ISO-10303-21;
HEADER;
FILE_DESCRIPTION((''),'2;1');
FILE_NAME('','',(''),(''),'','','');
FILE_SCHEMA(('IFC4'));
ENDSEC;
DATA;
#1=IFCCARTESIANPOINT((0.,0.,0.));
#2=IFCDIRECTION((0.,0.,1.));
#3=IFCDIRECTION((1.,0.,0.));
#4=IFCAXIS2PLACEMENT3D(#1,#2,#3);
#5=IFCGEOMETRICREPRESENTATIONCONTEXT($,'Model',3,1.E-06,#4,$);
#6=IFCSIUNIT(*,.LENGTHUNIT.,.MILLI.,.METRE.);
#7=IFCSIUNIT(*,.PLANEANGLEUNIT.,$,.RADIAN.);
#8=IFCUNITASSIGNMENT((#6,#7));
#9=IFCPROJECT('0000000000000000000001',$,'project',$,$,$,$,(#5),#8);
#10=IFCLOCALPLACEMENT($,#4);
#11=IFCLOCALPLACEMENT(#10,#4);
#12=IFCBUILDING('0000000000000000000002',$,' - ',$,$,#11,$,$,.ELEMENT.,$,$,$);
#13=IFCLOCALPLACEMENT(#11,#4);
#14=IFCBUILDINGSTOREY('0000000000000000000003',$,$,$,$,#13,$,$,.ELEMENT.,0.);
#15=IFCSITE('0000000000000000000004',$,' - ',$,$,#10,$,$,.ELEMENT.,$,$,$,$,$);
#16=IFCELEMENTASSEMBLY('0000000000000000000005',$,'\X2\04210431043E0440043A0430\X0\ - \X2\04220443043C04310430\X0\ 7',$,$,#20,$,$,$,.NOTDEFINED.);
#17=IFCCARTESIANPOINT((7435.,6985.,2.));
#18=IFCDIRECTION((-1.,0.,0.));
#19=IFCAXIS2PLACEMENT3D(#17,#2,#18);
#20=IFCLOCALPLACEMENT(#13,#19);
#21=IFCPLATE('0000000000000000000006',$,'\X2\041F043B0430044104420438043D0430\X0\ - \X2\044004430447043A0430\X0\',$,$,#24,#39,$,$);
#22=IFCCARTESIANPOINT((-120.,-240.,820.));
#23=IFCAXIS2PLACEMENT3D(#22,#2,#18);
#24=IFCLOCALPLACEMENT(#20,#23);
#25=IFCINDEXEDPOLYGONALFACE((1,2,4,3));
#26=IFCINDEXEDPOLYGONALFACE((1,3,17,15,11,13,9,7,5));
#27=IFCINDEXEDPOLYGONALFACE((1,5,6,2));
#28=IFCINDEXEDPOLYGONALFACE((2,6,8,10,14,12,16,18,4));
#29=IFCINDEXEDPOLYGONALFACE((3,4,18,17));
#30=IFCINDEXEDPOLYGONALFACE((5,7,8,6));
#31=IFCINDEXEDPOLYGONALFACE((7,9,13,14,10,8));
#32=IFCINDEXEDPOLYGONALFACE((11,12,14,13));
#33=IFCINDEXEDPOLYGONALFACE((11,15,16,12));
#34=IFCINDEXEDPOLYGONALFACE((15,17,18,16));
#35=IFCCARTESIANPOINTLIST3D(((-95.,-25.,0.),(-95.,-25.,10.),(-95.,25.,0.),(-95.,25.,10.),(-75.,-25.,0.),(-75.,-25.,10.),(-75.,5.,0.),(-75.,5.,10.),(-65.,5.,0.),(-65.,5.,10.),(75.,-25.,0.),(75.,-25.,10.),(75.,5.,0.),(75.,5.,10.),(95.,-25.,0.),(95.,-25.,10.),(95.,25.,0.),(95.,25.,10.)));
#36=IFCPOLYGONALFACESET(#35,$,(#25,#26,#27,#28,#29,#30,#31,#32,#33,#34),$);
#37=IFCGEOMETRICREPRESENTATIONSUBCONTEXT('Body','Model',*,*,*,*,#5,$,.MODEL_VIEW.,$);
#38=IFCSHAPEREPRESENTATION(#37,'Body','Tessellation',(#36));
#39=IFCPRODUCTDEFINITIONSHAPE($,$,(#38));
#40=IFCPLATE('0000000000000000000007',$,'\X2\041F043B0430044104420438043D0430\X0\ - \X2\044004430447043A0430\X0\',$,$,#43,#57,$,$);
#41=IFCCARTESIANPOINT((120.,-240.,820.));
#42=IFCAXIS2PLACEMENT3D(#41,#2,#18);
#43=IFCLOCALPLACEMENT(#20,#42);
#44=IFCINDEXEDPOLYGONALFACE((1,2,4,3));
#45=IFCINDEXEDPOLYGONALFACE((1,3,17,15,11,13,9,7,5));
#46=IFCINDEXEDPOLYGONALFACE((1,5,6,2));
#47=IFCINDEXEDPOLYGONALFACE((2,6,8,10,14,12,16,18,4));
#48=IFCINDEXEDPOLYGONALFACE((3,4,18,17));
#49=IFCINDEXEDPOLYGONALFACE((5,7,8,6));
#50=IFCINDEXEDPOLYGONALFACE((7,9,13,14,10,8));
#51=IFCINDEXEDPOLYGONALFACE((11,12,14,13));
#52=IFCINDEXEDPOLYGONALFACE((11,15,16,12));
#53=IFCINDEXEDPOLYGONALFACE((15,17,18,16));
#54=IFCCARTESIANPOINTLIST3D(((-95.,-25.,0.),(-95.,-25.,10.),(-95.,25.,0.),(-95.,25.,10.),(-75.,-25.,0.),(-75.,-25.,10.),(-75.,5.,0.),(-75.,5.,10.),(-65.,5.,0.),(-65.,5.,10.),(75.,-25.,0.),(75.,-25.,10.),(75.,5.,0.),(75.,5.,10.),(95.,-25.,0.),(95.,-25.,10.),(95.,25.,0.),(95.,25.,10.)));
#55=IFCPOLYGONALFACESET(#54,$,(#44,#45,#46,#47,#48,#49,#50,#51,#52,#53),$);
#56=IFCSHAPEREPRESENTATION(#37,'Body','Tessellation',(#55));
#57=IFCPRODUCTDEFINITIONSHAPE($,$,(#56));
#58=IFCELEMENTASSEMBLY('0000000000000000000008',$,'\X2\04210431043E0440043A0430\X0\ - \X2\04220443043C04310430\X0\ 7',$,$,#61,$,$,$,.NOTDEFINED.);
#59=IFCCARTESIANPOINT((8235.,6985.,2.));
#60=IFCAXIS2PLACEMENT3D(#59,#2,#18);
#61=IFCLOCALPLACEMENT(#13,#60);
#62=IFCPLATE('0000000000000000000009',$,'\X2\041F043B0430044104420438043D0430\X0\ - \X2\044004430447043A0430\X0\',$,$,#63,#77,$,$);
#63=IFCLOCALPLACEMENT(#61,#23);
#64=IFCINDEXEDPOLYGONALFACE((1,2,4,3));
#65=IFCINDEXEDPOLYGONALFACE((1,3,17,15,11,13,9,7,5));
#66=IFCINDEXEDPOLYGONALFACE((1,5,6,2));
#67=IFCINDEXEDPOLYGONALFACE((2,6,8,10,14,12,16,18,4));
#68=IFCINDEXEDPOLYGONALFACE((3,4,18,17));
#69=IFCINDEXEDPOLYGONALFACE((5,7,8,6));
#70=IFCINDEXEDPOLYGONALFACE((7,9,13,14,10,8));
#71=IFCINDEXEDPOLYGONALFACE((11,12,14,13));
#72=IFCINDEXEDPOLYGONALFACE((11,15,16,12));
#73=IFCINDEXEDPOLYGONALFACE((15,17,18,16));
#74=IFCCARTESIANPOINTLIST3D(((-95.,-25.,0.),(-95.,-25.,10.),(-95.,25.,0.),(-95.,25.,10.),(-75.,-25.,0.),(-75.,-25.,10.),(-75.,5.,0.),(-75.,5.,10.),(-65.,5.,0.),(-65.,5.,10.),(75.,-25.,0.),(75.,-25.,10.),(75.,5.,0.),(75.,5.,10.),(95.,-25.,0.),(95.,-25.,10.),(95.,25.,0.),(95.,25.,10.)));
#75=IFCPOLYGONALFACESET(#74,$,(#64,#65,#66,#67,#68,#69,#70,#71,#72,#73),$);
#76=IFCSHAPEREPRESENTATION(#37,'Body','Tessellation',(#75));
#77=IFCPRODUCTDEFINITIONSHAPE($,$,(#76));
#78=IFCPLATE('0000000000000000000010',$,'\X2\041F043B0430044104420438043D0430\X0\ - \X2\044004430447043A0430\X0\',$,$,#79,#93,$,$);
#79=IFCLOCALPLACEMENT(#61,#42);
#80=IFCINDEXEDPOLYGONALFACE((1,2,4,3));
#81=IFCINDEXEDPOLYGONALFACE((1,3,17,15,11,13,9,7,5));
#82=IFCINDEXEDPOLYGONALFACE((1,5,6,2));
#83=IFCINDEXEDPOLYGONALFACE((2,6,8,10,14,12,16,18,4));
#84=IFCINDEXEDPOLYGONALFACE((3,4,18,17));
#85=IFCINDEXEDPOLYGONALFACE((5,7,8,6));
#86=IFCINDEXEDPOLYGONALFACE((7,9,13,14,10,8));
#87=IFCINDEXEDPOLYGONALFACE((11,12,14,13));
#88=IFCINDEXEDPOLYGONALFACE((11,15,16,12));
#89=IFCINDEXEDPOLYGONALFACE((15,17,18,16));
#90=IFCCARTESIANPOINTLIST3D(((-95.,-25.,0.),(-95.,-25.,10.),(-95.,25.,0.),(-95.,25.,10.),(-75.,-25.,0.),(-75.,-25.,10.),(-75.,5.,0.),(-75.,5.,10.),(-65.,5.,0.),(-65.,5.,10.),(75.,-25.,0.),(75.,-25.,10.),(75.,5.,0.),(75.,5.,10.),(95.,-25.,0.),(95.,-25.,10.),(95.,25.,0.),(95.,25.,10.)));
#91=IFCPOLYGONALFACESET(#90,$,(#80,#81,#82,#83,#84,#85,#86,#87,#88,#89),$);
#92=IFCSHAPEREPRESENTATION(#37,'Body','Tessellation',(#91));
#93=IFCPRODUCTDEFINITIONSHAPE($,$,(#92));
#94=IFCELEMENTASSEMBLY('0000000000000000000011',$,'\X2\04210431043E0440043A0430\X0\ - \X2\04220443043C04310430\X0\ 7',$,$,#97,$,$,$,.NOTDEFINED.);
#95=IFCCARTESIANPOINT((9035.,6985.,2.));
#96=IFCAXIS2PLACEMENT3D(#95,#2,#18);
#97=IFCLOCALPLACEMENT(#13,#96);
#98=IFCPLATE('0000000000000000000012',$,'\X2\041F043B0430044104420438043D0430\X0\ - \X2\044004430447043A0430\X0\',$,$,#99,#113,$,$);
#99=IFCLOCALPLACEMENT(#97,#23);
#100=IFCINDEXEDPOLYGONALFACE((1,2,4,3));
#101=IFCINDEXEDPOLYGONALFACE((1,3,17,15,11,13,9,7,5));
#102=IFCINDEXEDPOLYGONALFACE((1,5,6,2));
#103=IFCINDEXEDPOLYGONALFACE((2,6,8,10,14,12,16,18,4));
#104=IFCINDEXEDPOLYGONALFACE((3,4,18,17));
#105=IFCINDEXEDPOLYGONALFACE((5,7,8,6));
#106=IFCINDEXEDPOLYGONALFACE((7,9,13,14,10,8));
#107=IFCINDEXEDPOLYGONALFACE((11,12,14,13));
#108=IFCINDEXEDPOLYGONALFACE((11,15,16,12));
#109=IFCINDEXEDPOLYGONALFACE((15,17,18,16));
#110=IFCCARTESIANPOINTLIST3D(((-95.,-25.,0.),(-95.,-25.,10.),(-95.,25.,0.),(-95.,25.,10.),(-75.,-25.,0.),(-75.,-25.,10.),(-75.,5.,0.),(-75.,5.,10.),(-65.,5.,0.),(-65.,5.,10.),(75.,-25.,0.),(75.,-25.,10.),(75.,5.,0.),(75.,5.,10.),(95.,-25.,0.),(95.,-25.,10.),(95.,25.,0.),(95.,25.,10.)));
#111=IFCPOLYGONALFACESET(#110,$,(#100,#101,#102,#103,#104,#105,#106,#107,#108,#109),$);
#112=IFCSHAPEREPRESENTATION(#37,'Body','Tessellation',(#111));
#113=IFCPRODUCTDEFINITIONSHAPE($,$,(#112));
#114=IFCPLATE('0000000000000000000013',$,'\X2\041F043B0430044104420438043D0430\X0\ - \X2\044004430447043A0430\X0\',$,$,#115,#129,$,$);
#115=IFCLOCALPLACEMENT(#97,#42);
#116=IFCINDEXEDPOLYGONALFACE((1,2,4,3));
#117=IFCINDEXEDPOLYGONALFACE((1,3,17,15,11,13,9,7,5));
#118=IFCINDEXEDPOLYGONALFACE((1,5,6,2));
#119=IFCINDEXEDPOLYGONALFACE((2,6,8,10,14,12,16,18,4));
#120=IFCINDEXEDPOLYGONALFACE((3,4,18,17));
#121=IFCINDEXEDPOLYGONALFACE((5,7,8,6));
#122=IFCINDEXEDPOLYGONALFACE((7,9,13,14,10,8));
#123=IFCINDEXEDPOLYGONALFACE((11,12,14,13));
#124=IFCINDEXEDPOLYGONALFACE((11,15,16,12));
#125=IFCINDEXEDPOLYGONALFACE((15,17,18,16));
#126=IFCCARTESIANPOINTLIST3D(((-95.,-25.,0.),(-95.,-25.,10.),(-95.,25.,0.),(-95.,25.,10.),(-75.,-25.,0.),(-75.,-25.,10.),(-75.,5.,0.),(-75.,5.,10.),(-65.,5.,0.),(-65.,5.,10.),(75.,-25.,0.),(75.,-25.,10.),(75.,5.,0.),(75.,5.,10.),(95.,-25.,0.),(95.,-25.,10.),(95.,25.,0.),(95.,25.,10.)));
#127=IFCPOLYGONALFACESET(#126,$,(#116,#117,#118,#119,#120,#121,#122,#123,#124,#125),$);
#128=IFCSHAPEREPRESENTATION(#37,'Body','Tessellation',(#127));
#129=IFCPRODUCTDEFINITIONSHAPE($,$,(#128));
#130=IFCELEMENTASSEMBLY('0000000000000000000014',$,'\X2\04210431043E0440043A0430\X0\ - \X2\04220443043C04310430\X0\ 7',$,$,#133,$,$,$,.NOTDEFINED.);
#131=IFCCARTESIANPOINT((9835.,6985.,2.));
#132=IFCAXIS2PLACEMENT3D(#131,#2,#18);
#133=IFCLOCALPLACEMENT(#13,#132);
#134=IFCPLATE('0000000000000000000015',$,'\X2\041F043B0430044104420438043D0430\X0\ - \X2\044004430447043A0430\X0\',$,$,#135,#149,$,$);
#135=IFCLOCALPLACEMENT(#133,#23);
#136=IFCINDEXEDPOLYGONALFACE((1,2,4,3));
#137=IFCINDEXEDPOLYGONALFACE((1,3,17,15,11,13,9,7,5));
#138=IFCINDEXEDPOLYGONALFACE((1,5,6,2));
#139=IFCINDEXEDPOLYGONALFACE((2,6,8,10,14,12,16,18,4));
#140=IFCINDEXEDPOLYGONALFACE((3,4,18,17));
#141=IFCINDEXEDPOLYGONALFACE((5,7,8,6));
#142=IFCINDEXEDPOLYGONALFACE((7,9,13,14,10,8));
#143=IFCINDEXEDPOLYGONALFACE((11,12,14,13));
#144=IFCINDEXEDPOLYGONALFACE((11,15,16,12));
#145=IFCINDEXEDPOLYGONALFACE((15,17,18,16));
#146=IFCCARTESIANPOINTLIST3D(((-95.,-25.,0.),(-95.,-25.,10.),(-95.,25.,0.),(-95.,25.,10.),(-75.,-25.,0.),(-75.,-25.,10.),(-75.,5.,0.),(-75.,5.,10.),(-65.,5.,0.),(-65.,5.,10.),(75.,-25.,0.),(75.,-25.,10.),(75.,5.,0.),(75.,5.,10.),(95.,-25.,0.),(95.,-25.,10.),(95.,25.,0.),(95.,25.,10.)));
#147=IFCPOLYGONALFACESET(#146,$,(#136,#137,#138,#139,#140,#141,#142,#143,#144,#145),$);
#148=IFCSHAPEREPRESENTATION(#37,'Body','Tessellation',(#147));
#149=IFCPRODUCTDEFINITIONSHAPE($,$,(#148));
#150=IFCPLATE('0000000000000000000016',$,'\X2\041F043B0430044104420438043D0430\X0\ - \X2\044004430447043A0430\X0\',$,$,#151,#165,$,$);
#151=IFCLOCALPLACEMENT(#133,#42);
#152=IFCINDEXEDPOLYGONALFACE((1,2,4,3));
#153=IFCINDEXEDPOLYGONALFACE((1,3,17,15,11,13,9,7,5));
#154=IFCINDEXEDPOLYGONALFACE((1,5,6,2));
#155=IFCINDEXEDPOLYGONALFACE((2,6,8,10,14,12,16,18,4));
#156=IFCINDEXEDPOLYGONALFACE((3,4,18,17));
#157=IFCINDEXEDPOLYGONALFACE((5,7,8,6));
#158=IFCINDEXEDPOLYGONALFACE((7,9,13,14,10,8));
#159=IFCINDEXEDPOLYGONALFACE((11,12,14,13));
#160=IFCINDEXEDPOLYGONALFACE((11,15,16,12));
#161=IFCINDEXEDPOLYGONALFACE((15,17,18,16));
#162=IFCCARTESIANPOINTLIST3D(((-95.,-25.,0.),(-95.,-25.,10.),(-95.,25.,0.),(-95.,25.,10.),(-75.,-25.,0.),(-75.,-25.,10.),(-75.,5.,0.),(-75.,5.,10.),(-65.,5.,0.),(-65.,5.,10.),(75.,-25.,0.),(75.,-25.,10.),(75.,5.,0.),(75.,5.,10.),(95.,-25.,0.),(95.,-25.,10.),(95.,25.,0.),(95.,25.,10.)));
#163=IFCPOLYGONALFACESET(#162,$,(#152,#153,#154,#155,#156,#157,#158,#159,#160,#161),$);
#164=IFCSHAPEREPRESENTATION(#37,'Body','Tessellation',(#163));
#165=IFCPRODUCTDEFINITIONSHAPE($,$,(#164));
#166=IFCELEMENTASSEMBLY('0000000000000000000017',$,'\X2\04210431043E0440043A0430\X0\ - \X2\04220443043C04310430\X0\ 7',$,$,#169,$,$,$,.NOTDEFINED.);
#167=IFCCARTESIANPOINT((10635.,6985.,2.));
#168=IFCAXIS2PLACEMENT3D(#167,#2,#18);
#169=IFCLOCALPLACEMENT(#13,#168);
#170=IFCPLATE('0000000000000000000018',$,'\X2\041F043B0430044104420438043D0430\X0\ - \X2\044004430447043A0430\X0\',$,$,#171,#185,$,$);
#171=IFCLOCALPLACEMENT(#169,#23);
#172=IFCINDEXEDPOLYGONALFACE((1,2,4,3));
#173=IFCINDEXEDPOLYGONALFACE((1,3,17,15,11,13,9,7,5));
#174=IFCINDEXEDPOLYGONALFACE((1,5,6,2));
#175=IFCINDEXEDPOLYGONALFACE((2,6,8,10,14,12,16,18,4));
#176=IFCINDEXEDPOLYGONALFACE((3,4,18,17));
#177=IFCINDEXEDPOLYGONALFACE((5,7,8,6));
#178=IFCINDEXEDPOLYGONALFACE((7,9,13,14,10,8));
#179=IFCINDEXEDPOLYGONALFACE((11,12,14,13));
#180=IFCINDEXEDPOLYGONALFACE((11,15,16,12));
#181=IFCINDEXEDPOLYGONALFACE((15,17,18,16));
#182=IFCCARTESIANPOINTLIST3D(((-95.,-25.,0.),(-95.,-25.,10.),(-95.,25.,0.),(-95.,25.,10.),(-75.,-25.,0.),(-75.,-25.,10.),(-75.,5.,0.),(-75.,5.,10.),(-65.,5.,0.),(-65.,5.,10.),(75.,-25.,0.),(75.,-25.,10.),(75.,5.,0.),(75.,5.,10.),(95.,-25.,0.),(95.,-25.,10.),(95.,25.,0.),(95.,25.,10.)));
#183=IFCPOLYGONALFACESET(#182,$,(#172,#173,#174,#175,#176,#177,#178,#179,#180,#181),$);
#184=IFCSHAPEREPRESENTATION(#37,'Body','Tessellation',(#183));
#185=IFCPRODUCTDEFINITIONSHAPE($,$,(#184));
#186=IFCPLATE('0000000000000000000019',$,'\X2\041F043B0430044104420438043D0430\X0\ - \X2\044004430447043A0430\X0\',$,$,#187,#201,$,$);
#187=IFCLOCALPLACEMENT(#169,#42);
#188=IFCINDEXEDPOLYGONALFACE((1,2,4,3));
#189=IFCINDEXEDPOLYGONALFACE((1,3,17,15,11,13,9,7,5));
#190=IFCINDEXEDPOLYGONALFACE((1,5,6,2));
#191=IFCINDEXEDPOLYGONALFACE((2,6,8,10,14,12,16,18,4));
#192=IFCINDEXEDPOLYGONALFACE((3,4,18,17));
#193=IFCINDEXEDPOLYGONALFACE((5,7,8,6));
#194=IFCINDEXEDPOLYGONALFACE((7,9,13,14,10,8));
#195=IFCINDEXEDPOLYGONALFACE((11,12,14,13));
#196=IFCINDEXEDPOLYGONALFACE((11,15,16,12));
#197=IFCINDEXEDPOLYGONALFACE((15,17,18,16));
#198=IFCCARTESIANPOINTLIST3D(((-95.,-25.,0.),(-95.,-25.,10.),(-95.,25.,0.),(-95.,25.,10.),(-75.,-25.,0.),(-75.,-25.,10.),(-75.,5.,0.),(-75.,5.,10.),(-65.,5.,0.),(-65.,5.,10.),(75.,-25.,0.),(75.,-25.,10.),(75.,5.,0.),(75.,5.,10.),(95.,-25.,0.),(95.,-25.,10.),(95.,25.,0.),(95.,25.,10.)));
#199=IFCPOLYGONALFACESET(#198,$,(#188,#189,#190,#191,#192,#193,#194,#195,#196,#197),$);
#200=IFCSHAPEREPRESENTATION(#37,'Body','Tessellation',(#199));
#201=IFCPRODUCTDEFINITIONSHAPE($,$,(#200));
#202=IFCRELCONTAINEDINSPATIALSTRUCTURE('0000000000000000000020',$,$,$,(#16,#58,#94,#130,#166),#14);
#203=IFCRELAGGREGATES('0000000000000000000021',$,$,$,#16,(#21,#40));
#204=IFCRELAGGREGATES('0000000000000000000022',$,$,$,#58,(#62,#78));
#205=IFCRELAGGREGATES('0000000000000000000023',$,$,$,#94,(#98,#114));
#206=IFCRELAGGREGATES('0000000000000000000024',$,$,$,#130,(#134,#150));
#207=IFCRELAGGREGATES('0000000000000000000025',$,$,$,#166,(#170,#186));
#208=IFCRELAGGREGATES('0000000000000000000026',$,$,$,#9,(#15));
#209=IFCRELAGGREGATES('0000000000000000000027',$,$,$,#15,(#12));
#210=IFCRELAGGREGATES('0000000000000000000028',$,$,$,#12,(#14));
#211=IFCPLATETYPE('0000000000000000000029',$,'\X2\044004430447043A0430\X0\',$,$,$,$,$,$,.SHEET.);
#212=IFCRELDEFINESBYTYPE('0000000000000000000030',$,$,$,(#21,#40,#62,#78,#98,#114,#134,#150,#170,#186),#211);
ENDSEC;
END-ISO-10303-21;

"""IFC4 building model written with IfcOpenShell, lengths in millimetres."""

from ifc_helpers import new_model, si_unit, frame, origin_with_axes, place, context, subcontext, project, spatial, line, indexed_curve, outline, extrude, source, transform, mapped, type_object, element, aggregate, save


model = new_model("IFC4")

# Units and contexts
model_context = context("Model", 3, precision=1e-06, world=origin_with_axes())
body_context = subcontext(model_context, "Body", "Model", "MODEL_VIEW")
ifc_project = project(units=[si_unit("LENGTHUNIT", "METRE", prefix="MILLI"), si_unit("PLANEANGLEUNIT", "RADIAN")], contexts=[model_context])

# Site, building, storey
site_placement = place(None, origin_with_axes())
site = spatial("IfcSite", under=ifc_project, at=site_placement, Name=" - ", CompositionType="ELEMENT")
building_placement = place(site_placement, origin_with_axes())
building = spatial("IfcBuilding", under=site, at=building_placement, Name=" - ", CompositionType="ELEMENT")
storey_placement = place(building_placement, origin_with_axes())
storey = spatial("IfcBuildingStorey", under=building, at=storey_placement, CompositionType="ELEMENT", Elevation=0.0)

# Element assemblies, plates
assembly_1_placement = place(storey_placement, frame((7435.0, 6985.0, 2.0), z_axis=(0.0, 0.0, 1.0), x_axis=(-1.0, 0.0, 0.0)))
assembly_1 = element("IfcElementAssembly", 1, at=assembly_1_placement, inside=storey, Name="Сборка - Тумба 7", PredefinedType="NOTDEFINED")
plate_type = type_object("IfcPlateType", Name="ручка", PredefinedType="SHEET")
shared_shape_1 = source(origin_with_axes(), body_context, "Body", "SweptSolid", [
    extrude(outline(indexed_curve([(-95.0, -25.0), (-75.0, -25.0), (-75.0, 5.0), (-65.0, 5.0), (75.0, 5.0), (75.0, -25.0), (95.0, -25.0), (95.0, 25.0), (-95.0, 25.0)], segments=[line(1, 2), line(2, 3), line(3, 4), line(4, 5), line(5, 6), line(6, 7), line(7, 8), line(8, 9), line(9, 1)])), origin_with_axes(), (0.0, 0.0, 1.0), 10.0),
])
plate_1_placement = place(assembly_1_placement, frame((-120.0, -240.0, 820.0), z_axis=(0.0, 0.0, 1.0), x_axis=(-1.0, 0.0, 0.0)))
plate_1 = element("IfcPlate", 2, at=plate_1_placement, type_object=plate_type, Name="Пластина - ручка", context=body_context, shape_type="MappedRepresentation", body=[
    mapped(shared_shape_1, transform((0.0, 0.0, 0.0), x_axis=(1.0, 0.0, 0.0), y_axis=(0.0, 1.0, 0.0), z_axis=(0.0, 0.0, 1.0), scale=1.0)),
])
plate_2_placement = place(assembly_1_placement, frame((120.0, -240.0, 820.0), z_axis=(0.0, 0.0, 1.0), x_axis=(-1.0, 0.0, 0.0)))
plate_2 = element("IfcPlate", 3, at=plate_2_placement, type_object=plate_type, Name="Пластина - ручка", context=body_context, shape_type="MappedRepresentation", body=[
    mapped(shared_shape_1, transform((0.0, 0.0, 0.0), x_axis=(1.0, 0.0, 0.0), y_axis=(0.0, 1.0, 0.0), z_axis=(0.0, 0.0, 1.0), scale=1.0)),
])
aggregate(assembly_1, [plate_1, plate_2])
assembly_2_placement = place(storey_placement, frame((8235.0, 6985.0, 2.0), z_axis=(0.0, 0.0, 1.0), x_axis=(-1.0, 0.0, 0.0)))
assembly_2 = element("IfcElementAssembly", 4, at=assembly_2_placement, inside=storey, Name="Сборка - Тумба 7", PredefinedType="NOTDEFINED")
plate_3_placement = place(assembly_2_placement, frame((-120.0, -240.0, 820.0), z_axis=(0.0, 0.0, 1.0), x_axis=(-1.0, 0.0, 0.0)))
plate_3 = element("IfcPlate", 5, at=plate_3_placement, type_object=plate_type, Name="Пластина - ручка", context=body_context, shape_type="MappedRepresentation", body=[
    mapped(shared_shape_1, transform((0.0, 0.0, 0.0), x_axis=(1.0, 0.0, 0.0), y_axis=(0.0, 1.0, 0.0), z_axis=(0.0, 0.0, 1.0), scale=1.0)),
])
plate_4_placement = place(assembly_2_placement, frame((120.0, -240.0, 820.0), z_axis=(0.0, 0.0, 1.0), x_axis=(-1.0, 0.0, 0.0)))
plate_4 = element("IfcPlate", 6, at=plate_4_placement, type_object=plate_type, Name="Пластина - ручка", context=body_context, shape_type="MappedRepresentation", body=[
    mapped(shared_shape_1, transform((0.0, 0.0, 0.0), x_axis=(1.0, 0.0, 0.0), y_axis=(0.0, 1.0, 0.0), z_axis=(0.0, 0.0, 1.0), scale=1.0)),
])
aggregate(assembly_2, [plate_3, plate_4])
assembly_3_placement = place(storey_placement, frame((9035.0, 6985.0, 2.0), z_axis=(0.0, 0.0, 1.0), x_axis=(-1.0, 0.0, 0.0)))
assembly_3 = element("IfcElementAssembly", 7, at=assembly_3_placement, inside=storey, Name="Сборка - Тумба 7", PredefinedType="NOTDEFINED")
plate_5_placement = place(assembly_3_placement, frame((-120.0, -240.0, 820.0), z_axis=(0.0, 0.0, 1.0), x_axis=(-1.0, 0.0, 0.0)))
plate_5 = element("IfcPlate", 8, at=plate_5_placement, type_object=plate_type, Name="Пластина - ручка", context=body_context, shape_type="MappedRepresentation", body=[
    mapped(shared_shape_1, transform((0.0, 0.0, 0.0), x_axis=(1.0, 0.0, 0.0), y_axis=(0.0, 1.0, 0.0), z_axis=(0.0, 0.0, 1.0), scale=1.0)),
])
plate_6_placement = place(assembly_3_placement, frame((120.0, -240.0, 820.0), z_axis=(0.0, 0.0, 1.0), x_axis=(-1.0, 0.0, 0.0)))
plate_6 = element("IfcPlate", 9, at=plate_6_placement, type_object=plate_type, Name="Пластина - ручка", context=body_context, shape_type="MappedRepresentation", body=[
    mapped(shared_shape_1, transform((0.0, 0.0, 0.0), x_axis=(1.0, 0.0, 0.0), y_axis=(0.0, 1.0, 0.0), z_axis=(0.0, 0.0, 1.0), scale=1.0)),
])
aggregate(assembly_3, [plate_5, plate_6])
assembly_4_placement = place(storey_placement, frame((9835.0, 6985.0, 2.0), z_axis=(0.0, 0.0, 1.0), x_axis=(-1.0, 0.0, 0.0)))
assembly_4 = element("IfcElementAssembly", 10, at=assembly_4_placement, inside=storey, Name="Сборка - Тумба 7", PredefinedType="NOTDEFINED")
plate_7_placement = place(assembly_4_placement, frame((-120.0, -240.0, 820.0), z_axis=(0.0, 0.0, 1.0), x_axis=(-1.0, 0.0, 0.0)))
plate_7 = element("IfcPlate", 11, at=plate_7_placement, type_object=plate_type, Name="Пластина - ручка", context=body_context, shape_type="MappedRepresentation", body=[
    mapped(shared_shape_1, transform((0.0, 0.0, 0.0), x_axis=(1.0, 0.0, 0.0), y_axis=(0.0, 1.0, 0.0), z_axis=(0.0, 0.0, 1.0), scale=1.0)),
])
plate_8_placement = place(assembly_4_placement, frame((120.0, -240.0, 820.0), z_axis=(0.0, 0.0, 1.0), x_axis=(-1.0, 0.0, 0.0)))
plate_8 = element("IfcPlate", 12, at=plate_8_placement, type_object=plate_type, Name="Пластина - ручка", context=body_context, shape_type="MappedRepresentation", body=[
    mapped(shared_shape_1, transform((0.0, 0.0, 0.0), x_axis=(1.0, 0.0, 0.0), y_axis=(0.0, 1.0, 0.0), z_axis=(0.0, 0.0, 1.0), scale=1.0)),
])
aggregate(assembly_4, [plate_7, plate_8])
assembly_5_placement = place(storey_placement, frame((10635.0, 6985.0, 2.0), z_axis=(0.0, 0.0, 1.0), x_axis=(-1.0, 0.0, 0.0)))
assembly_5 = element("IfcElementAssembly", 13, at=assembly_5_placement, inside=storey, Name="Сборка - Тумба 7", PredefinedType="NOTDEFINED")
plate_9_placement = place(assembly_5_placement, frame((-120.0, -240.0, 820.0), z_axis=(0.0, 0.0, 1.0), x_axis=(-1.0, 0.0, 0.0)))
plate_9 = element("IfcPlate", 14, at=plate_9_placement, type_object=plate_type, Name="Пластина - ручка", context=body_context, shape_type="MappedRepresentation", body=[
    mapped(shared_shape_1, transform((0.0, 0.0, 0.0), x_axis=(1.0, 0.0, 0.0), y_axis=(0.0, 1.0, 0.0), z_axis=(0.0, 0.0, 1.0), scale=1.0)),
])
plate_10_placement = place(assembly_5_placement, frame((120.0, -240.0, 820.0), z_axis=(0.0, 0.0, 1.0), x_axis=(-1.0, 0.0, 0.0)))
plate_10 = element("IfcPlate", 15, at=plate_10_placement, type_object=plate_type, Name="Пластина - ручка", context=body_context, shape_type="MappedRepresentation", body=[
    mapped(shared_shape_1, transform((0.0, 0.0, 0.0), x_axis=(1.0, 0.0, 0.0), y_axis=(0.0, 1.0, 0.0), z_axis=(0.0, 0.0, 1.0), scale=1.0)),
])
aggregate(assembly_5, [plate_9, plate_10])

save(model, "model.ifc")
